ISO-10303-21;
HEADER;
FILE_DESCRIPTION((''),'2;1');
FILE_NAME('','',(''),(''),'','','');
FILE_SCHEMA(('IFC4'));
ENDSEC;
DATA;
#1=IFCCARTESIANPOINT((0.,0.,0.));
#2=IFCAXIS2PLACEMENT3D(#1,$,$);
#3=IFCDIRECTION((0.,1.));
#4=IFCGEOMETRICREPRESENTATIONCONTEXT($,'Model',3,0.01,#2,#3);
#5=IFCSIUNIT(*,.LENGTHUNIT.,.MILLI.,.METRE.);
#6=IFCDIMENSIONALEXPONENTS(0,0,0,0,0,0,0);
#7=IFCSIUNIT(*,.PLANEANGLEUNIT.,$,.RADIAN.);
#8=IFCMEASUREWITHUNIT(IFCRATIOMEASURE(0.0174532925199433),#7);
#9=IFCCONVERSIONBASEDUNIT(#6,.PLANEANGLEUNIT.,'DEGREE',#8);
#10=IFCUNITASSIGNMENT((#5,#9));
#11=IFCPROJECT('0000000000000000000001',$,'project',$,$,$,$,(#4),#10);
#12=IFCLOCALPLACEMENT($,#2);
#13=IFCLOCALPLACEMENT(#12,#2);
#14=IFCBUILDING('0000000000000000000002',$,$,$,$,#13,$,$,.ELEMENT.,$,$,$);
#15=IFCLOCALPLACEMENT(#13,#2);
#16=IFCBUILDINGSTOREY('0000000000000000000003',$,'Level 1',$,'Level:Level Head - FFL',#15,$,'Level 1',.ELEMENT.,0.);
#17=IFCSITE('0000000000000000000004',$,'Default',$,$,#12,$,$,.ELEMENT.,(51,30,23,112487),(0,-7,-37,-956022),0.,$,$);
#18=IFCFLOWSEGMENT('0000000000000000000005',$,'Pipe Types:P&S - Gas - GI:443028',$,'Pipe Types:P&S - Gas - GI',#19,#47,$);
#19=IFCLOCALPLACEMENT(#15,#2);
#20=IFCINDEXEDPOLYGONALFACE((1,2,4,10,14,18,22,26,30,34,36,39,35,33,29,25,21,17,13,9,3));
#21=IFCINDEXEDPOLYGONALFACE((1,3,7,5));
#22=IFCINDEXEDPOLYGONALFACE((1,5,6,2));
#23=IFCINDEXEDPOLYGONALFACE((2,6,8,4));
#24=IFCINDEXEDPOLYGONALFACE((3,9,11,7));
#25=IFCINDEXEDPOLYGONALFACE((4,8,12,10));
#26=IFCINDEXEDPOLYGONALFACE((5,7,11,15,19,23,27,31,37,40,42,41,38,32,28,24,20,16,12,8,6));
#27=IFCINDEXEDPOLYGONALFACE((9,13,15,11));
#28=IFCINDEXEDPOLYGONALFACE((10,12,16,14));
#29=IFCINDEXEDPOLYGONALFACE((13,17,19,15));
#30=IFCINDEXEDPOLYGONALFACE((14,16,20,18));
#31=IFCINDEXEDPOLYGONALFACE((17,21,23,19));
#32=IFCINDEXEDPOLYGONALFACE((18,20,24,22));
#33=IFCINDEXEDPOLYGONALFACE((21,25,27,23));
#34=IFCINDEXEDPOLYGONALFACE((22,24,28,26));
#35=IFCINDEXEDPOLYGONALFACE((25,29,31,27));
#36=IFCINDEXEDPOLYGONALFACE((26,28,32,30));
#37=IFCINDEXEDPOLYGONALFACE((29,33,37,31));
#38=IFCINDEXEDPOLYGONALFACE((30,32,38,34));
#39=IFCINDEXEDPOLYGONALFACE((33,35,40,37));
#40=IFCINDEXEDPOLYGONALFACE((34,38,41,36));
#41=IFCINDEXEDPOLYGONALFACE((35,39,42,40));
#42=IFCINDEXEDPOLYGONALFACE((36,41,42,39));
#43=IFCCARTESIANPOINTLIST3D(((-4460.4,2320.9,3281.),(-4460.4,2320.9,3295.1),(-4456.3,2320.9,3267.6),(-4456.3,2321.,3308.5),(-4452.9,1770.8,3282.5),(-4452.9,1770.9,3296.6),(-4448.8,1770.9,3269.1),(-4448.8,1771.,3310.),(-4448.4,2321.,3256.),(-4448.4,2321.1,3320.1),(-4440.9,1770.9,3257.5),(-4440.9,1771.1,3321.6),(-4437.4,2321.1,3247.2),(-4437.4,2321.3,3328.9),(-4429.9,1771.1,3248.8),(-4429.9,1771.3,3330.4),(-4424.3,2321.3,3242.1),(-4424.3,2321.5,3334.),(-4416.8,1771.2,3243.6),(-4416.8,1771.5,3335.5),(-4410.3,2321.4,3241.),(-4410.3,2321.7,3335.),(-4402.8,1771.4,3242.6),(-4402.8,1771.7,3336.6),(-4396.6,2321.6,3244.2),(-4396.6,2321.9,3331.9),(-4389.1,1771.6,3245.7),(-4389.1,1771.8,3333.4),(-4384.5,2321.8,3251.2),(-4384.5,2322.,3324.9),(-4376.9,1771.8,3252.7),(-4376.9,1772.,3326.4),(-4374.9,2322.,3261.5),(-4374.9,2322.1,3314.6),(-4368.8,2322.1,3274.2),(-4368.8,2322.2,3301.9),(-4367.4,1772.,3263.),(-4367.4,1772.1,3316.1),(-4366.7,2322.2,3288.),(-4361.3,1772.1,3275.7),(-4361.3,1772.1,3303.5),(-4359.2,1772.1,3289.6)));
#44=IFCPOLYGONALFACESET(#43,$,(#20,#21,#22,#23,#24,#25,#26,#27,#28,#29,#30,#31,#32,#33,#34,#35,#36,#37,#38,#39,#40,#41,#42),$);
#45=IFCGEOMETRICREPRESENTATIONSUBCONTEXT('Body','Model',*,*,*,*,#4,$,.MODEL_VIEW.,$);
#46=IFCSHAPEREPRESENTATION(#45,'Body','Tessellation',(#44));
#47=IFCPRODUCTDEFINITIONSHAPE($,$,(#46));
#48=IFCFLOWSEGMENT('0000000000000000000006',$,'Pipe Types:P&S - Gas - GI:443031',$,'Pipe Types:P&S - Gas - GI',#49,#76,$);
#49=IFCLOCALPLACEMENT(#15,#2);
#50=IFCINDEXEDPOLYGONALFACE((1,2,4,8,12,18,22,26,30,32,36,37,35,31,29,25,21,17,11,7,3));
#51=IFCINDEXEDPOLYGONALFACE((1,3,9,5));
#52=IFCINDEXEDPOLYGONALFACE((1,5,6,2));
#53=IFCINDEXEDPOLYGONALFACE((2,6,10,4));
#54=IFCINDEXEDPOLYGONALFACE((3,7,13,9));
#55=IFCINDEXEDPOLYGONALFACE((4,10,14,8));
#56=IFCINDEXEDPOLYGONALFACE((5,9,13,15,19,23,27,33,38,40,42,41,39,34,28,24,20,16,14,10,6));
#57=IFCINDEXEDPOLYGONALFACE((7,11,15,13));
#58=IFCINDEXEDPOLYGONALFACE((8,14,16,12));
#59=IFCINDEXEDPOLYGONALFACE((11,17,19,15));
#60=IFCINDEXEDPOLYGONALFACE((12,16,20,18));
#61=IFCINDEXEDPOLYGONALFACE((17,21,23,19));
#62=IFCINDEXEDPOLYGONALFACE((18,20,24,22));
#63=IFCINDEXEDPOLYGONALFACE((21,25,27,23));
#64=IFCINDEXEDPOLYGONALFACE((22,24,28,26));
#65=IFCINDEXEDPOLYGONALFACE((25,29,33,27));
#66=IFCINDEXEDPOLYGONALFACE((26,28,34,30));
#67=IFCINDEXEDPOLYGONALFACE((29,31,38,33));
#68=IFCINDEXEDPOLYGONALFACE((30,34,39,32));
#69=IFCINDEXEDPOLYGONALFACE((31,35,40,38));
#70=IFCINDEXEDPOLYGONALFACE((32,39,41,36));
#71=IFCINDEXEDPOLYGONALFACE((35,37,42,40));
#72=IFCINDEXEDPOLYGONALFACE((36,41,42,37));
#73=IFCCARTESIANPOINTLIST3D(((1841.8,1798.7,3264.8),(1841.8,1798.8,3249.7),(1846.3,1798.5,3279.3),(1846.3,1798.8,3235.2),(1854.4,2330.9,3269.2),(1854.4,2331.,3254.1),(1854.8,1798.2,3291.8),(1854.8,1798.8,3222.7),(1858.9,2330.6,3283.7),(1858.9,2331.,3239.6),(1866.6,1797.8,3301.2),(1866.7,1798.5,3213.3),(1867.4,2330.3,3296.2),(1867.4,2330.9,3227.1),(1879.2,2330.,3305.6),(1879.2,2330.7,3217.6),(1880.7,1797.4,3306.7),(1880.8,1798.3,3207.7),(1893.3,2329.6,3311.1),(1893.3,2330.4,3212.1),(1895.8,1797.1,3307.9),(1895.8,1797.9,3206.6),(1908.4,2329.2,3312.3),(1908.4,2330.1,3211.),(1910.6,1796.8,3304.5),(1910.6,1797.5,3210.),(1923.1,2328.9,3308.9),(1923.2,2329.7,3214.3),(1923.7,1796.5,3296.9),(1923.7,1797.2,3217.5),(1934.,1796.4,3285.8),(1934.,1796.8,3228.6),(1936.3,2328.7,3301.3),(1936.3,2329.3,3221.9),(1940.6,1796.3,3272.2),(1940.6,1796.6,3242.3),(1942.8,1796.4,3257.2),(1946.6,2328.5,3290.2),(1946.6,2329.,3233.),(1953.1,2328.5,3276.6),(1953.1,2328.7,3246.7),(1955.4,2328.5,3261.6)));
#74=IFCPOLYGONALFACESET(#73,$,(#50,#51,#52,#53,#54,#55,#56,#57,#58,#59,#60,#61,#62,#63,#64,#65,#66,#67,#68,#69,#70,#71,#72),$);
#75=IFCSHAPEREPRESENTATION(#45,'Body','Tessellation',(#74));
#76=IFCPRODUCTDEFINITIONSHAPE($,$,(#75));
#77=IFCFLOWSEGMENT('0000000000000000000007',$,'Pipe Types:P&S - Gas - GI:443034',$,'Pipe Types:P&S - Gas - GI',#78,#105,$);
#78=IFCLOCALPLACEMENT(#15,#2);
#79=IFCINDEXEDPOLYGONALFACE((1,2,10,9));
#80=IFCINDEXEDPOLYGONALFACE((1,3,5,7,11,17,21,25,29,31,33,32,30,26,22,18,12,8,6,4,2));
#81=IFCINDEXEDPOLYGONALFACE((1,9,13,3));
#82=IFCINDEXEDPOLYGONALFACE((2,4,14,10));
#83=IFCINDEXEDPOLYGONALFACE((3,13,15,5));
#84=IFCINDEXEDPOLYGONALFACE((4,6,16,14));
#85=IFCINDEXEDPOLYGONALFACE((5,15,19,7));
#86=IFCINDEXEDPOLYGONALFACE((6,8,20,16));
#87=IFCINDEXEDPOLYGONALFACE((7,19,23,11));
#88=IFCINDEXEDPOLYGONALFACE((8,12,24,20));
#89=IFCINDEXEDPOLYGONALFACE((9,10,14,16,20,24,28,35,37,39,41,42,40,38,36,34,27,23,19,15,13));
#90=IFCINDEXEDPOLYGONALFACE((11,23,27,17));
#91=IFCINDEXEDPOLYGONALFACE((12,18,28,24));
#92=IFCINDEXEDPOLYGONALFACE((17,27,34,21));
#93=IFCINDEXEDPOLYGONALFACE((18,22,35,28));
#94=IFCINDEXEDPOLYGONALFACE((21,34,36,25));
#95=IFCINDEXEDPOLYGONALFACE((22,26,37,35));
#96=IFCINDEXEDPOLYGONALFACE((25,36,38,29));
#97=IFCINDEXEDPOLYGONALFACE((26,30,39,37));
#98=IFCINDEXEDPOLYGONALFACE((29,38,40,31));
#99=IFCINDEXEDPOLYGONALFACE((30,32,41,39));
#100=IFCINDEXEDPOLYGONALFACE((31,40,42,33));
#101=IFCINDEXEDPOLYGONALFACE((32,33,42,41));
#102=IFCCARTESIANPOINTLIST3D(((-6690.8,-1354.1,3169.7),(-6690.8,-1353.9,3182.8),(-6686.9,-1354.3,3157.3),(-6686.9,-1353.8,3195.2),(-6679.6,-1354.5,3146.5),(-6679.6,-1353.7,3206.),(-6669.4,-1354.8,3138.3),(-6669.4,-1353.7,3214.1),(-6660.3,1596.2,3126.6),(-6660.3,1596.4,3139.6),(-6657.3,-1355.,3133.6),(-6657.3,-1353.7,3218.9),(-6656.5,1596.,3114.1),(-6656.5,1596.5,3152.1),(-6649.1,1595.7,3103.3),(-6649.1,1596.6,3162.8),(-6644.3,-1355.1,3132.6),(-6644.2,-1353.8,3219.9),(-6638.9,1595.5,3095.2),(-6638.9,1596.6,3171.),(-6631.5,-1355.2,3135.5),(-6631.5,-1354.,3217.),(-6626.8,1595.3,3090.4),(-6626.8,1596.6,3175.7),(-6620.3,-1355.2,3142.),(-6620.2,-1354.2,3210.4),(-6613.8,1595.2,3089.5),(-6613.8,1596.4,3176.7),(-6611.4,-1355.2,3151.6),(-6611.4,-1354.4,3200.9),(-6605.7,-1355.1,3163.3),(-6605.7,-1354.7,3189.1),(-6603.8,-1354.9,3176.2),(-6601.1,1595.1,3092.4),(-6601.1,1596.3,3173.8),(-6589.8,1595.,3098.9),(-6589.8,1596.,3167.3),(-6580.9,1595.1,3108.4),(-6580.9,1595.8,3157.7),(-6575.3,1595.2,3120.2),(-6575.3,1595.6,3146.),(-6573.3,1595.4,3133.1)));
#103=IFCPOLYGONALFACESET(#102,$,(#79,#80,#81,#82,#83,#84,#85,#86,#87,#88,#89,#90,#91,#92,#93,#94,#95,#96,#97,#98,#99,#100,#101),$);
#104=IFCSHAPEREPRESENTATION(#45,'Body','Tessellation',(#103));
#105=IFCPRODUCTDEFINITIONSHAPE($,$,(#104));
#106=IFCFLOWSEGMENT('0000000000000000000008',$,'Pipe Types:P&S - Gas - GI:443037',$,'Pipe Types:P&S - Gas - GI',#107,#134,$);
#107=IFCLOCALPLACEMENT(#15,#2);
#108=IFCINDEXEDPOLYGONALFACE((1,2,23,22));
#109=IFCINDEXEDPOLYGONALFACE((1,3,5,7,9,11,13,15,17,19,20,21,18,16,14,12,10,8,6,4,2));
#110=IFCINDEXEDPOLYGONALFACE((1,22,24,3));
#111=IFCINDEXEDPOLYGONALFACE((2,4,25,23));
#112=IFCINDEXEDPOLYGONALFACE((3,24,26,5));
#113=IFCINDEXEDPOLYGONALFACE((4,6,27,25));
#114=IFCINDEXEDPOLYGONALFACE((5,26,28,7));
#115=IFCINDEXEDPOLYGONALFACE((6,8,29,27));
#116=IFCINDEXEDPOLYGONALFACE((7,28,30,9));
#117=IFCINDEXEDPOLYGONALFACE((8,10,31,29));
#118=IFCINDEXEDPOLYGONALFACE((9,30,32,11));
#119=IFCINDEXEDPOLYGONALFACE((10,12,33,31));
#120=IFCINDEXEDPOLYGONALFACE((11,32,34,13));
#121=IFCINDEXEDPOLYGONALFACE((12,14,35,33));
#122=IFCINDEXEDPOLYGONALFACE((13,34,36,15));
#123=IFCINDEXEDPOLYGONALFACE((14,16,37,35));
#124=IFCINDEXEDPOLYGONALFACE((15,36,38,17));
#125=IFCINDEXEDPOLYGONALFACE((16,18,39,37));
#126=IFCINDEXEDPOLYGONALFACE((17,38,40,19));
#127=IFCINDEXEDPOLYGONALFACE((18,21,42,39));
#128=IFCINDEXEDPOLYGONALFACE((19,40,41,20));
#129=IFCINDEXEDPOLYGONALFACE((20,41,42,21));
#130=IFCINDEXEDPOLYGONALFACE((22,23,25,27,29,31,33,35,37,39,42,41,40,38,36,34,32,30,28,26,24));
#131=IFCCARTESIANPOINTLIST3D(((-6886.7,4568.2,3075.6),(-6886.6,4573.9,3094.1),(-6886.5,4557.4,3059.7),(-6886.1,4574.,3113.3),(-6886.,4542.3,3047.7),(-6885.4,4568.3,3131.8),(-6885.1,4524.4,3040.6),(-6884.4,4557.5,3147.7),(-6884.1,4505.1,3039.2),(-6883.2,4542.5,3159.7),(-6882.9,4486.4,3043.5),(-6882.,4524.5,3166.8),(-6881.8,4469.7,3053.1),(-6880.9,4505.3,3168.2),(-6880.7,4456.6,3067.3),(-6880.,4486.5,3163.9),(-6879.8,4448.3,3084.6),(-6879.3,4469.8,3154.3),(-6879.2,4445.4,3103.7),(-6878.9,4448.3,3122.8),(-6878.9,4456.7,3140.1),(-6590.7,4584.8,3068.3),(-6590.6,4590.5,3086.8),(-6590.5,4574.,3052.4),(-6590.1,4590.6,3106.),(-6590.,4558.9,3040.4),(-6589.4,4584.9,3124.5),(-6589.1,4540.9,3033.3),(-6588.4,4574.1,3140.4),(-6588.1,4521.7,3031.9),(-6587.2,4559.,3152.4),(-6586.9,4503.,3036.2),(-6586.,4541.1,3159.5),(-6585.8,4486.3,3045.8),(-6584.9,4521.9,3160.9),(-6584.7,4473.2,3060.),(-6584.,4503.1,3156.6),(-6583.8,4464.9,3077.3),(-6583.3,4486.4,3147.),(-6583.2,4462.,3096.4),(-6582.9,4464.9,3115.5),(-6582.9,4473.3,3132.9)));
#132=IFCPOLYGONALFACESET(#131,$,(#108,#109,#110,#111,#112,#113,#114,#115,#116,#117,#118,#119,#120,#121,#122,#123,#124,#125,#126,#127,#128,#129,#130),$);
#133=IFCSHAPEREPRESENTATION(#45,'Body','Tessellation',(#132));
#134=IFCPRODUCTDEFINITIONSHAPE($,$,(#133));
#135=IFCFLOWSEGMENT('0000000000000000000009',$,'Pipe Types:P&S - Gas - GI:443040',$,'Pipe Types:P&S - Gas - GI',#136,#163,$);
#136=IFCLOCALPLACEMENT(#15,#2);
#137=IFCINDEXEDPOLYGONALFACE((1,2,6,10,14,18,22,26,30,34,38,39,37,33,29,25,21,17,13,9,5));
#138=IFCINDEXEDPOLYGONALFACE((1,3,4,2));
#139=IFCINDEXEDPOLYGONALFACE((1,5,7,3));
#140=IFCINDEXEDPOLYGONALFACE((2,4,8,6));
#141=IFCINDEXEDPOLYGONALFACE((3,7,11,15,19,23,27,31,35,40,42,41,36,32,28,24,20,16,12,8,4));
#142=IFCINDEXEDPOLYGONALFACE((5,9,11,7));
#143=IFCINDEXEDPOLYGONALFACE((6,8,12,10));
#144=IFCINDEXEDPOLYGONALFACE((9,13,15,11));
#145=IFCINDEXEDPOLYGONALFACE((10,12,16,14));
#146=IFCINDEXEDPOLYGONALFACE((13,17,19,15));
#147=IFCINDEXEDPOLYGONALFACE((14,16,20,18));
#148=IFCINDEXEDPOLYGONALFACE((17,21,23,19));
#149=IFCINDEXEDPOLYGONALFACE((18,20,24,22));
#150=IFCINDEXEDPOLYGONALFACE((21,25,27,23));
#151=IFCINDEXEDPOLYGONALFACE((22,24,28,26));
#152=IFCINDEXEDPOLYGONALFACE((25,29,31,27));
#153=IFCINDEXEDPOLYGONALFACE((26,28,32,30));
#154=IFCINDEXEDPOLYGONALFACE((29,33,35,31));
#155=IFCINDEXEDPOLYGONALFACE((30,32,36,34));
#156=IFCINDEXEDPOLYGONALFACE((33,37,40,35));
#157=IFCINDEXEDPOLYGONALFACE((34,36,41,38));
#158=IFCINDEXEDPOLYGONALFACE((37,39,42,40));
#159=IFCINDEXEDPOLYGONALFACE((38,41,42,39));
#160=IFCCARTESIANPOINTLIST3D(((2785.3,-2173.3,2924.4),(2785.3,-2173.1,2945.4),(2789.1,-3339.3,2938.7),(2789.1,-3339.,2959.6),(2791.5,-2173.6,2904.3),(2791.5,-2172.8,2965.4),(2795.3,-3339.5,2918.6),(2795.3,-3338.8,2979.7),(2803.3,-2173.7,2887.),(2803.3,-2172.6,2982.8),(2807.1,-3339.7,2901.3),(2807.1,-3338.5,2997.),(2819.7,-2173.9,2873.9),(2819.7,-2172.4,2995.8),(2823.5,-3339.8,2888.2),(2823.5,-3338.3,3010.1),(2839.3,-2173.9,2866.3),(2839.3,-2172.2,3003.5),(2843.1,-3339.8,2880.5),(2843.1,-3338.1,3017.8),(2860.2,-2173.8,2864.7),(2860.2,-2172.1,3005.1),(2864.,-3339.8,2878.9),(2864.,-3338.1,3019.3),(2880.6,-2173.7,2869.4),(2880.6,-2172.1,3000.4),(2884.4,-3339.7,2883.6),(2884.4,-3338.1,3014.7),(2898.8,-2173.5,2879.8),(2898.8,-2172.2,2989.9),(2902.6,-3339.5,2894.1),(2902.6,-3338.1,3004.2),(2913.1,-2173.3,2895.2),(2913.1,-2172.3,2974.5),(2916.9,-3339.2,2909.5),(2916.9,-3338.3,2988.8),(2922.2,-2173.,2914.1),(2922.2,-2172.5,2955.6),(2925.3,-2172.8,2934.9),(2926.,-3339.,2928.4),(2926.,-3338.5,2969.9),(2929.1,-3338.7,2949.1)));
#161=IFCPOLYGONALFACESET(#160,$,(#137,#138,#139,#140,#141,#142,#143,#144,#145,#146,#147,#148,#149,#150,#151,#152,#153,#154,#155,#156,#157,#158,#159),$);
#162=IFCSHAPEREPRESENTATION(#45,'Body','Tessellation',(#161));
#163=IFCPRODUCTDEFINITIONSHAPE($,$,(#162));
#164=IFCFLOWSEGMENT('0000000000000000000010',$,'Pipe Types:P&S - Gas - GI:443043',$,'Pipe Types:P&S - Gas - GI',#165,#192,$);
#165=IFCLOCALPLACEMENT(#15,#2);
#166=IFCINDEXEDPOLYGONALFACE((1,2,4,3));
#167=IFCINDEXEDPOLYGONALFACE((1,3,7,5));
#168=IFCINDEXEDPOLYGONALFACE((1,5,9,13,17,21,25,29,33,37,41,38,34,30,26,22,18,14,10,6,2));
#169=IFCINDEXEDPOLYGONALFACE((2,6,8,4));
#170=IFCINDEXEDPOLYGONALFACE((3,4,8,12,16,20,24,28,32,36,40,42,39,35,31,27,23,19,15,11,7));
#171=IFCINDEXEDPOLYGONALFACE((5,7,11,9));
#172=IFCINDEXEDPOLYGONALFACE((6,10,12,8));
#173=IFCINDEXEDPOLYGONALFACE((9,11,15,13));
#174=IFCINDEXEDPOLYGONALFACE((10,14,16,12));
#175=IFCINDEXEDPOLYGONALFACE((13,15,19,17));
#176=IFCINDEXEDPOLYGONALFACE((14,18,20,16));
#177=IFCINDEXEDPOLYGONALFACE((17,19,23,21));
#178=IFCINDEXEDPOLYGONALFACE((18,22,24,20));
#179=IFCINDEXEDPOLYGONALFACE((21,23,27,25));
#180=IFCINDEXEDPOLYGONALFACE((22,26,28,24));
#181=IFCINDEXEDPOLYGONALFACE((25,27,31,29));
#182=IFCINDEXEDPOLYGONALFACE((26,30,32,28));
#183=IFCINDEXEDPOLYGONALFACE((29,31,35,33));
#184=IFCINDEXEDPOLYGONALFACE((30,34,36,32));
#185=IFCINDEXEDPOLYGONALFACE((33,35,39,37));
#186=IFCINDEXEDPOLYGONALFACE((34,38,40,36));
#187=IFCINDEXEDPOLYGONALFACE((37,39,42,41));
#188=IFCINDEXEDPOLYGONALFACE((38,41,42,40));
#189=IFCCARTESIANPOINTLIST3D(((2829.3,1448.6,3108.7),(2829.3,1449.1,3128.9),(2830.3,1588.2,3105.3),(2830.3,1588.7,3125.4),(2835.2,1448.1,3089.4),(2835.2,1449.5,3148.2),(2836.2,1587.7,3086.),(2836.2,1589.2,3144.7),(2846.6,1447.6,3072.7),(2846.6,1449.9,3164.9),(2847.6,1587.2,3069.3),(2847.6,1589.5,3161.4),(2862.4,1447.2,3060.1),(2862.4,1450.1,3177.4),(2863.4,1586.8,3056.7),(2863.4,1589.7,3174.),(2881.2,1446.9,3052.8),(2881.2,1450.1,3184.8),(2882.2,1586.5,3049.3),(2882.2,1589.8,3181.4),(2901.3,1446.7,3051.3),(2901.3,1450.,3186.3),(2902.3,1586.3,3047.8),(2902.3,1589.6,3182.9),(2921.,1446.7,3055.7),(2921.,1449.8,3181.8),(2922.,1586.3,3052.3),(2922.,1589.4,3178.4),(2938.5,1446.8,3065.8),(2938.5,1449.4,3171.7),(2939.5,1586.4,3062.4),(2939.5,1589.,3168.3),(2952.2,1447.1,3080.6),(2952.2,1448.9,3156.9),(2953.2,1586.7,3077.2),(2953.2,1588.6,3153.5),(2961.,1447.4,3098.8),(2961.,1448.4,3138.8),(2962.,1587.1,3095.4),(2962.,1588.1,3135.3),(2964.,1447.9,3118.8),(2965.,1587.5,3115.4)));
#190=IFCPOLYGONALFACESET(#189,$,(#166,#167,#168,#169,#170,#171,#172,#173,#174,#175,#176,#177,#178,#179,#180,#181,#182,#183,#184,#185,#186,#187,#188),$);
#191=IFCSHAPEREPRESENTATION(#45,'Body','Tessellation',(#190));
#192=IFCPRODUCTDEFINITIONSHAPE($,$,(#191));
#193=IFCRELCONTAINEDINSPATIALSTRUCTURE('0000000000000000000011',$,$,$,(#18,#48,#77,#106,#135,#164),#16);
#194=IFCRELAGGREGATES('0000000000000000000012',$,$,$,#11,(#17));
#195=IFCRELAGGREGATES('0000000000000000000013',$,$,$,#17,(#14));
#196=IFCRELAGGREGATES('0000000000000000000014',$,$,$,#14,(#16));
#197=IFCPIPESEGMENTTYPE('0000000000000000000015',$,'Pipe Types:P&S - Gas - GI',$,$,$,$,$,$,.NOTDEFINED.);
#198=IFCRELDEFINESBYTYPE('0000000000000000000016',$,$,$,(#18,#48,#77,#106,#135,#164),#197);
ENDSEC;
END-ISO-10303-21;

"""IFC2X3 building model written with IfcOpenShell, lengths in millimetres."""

from ifc_helpers import new_model, entity, si_unit, converted_unit, direction, frame, frame_2d, origin, origin_2d_with_axis, place, context, subcontext, project, spatial, circle, extrude, type_object, element, save


model = new_model("IFC2X3")

# Units and contexts
model_context = context("Model", 3, precision=0.01, world=origin(), true_north=direction((0.0, 1.0)))
body_context = subcontext(model_context, "Body", "Model", "MODEL_VIEW")
ifc_project = project(units=[si_unit("LENGTHUNIT", "METRE", prefix="MILLI"), converted_unit("PLANEANGLEUNIT", "DEGREE", entity("IfcRatioMeasure", 0.0174532925199433), si_unit("PLANEANGLEUNIT", "RADIAN"), dimensions=[0, 0, 0, 0, 0, 0, 0])], contexts=[model_context])

# Site, building, storey
site_placement = place(None, origin())
site = spatial("IfcSite", under=ifc_project, at=site_placement, Name="Default", CompositionType="ELEMENT", RefLatitude=(51, 30, 23, 112487), RefLongitude=(0, -7, -37, -956022), RefElevation=0.0)
building_placement = place(site_placement, origin())
building = spatial("IfcBuilding", under=site, at=building_placement, CompositionType="ELEMENT")
storey_placement = place(building_placement, origin())
storey = spatial("IfcBuildingStorey", under=building, at=storey_placement, Name="Level 1", ObjectType="Level:Level Head - FFL", LongName="Level 1", CompositionType="ELEMENT", Elevation=0.0)

# Flow segments
pipe_segment_type = type_object("IfcPipeSegmentType", Name="Pipe Types:P&S - Gas - GI", PredefinedType="NOTDEFINED")
flow_segment_1_placement = place(storey_placement, origin())
element("IfcFlowSegment", 1, at=flow_segment_1_placement, inside=storey, type_object=pipe_segment_type, Name="Pipe Types:P&S - Gas - GI:443028", ObjectType="Pipe Types:P&S - Gas - GI", context=body_context, shape_type="SweptSolid", body=[
    extrude(circle(Radius=47.1, at=frame_2d((0.0, 0.0), x_axis=(1.0, 0.0))), frame((-4413.8, 2321.5, 3288.0), z_axis=(0.013674, -0.999903, 0.002786), x_axis=(0.999907, 0.013674, 0.0)), (0.0, 0.0, 1.0), 550.1),
])
flow_segment_2_placement = place(storey_placement, origin())
element("IfcFlowSegment", 2, at=flow_segment_2_placement, inside=storey, type_object=pipe_segment_type, Name="Pipe Types:P&S - Gas - GI:443031", ObjectType="Pipe Types:P&S - Gas - GI", context=body_context, shape_type="SweptSolid", body=[
    extrude(circle(Radius=50.8, at=frame_2d((0.0, 0.0), x_axis=(1.0, 0.0))), frame((1892.0, 1797.6, 3257.2), z_axis=(0.023609, 0.999687, 0.008241), x_axis=(0.999721, -0.023609, 0.0)), (0.0, 0.0, 1.0), 532.3),
])
flow_segment_3_placement = place(storey_placement, origin())
element("IfcFlowSegment", 3, at=flow_segment_3_placement, inside=storey, type_object=pipe_segment_type, Name="Pipe Types:P&S - Gas - GI:443034", ObjectType="Pipe Types:P&S - Gas - GI", context=body_context, shape_type="SweptSolid", body=[
    extrude(circle(Radius=43.7, at=origin_2d_with_axis()), frame((-6617.1, 1595.8, 3133.1), z_axis=(-0.010322, -0.99984, 0.014622), x_axis=(0.999947, -0.010323, 0.0)), (0.0, 0.0, 1.0), 2950.7),
])
flow_segment_4_placement = place(storey_placement, origin())
element("IfcFlowSegment", 4, at=flow_segment_4_placement, inside=storey, type_object=pipe_segment_type, Name="Pipe Types:P&S - Gas - GI:443037", ObjectType="Pipe Types:P&S - Gas - GI", context=body_context, shape_type="SweptSolid", body=[
    extrude(circle(Radius=64.7, at=frame_2d((0.0, 0.0), x_axis=(1.0, 0.0))), frame((-6882.8, 4510.1, 3103.7), z_axis=(0.998133, 0.055918, -0.024589), x_axis=(0.055934, -0.998434, 0.0)), (0.0, 0.0, 1.0), 296.5),
])
flow_segment_5_placement = place(storey_placement, origin())
element("IfcFlowSegment", 5, at=flow_segment_5_placement, inside=storey, type_object=pipe_segment_type, Name="Pipe Types:P&S - Gas - GI:443040", ObjectType="Pipe Types:P&S - Gas - GI", context=body_context, shape_type="SweptSolid", body=[
    extrude(circle(Radius=70.4, at=frame_2d((0.0, 0.0), x_axis=(1.0, 0.0))), frame((2858.7, -3338.9, 2949.1), z_axis=(-0.003254, 0.99992, -0.012233), x_axis=(0.999995, 0.003255, 0.0)), (0.0, 0.0, 1.0), 1166.0),
])
flow_segment_6_placement = place(storey_placement, origin())
element("IfcFlowSegment", 6, at=flow_segment_6_placement, inside=storey, type_object=pipe_segment_type, Name="Pipe Types:P&S - Gas - GI:443043", ObjectType="Pipe Types:P&S - Gas - GI", context=body_context, shape_type="SweptSolid", body=[
    extrude(circle(Radius=67.7, at=origin_2d_with_axis()), frame((2897.3, 1588.0, 3115.4), z_axis=(-0.007096, -0.999672, 0.02462), x_axis=(0.999975, -0.007098, 0.0)), (0.0, 0.0, 1.0), 139.7),
])

save(model, "model.ifc")
